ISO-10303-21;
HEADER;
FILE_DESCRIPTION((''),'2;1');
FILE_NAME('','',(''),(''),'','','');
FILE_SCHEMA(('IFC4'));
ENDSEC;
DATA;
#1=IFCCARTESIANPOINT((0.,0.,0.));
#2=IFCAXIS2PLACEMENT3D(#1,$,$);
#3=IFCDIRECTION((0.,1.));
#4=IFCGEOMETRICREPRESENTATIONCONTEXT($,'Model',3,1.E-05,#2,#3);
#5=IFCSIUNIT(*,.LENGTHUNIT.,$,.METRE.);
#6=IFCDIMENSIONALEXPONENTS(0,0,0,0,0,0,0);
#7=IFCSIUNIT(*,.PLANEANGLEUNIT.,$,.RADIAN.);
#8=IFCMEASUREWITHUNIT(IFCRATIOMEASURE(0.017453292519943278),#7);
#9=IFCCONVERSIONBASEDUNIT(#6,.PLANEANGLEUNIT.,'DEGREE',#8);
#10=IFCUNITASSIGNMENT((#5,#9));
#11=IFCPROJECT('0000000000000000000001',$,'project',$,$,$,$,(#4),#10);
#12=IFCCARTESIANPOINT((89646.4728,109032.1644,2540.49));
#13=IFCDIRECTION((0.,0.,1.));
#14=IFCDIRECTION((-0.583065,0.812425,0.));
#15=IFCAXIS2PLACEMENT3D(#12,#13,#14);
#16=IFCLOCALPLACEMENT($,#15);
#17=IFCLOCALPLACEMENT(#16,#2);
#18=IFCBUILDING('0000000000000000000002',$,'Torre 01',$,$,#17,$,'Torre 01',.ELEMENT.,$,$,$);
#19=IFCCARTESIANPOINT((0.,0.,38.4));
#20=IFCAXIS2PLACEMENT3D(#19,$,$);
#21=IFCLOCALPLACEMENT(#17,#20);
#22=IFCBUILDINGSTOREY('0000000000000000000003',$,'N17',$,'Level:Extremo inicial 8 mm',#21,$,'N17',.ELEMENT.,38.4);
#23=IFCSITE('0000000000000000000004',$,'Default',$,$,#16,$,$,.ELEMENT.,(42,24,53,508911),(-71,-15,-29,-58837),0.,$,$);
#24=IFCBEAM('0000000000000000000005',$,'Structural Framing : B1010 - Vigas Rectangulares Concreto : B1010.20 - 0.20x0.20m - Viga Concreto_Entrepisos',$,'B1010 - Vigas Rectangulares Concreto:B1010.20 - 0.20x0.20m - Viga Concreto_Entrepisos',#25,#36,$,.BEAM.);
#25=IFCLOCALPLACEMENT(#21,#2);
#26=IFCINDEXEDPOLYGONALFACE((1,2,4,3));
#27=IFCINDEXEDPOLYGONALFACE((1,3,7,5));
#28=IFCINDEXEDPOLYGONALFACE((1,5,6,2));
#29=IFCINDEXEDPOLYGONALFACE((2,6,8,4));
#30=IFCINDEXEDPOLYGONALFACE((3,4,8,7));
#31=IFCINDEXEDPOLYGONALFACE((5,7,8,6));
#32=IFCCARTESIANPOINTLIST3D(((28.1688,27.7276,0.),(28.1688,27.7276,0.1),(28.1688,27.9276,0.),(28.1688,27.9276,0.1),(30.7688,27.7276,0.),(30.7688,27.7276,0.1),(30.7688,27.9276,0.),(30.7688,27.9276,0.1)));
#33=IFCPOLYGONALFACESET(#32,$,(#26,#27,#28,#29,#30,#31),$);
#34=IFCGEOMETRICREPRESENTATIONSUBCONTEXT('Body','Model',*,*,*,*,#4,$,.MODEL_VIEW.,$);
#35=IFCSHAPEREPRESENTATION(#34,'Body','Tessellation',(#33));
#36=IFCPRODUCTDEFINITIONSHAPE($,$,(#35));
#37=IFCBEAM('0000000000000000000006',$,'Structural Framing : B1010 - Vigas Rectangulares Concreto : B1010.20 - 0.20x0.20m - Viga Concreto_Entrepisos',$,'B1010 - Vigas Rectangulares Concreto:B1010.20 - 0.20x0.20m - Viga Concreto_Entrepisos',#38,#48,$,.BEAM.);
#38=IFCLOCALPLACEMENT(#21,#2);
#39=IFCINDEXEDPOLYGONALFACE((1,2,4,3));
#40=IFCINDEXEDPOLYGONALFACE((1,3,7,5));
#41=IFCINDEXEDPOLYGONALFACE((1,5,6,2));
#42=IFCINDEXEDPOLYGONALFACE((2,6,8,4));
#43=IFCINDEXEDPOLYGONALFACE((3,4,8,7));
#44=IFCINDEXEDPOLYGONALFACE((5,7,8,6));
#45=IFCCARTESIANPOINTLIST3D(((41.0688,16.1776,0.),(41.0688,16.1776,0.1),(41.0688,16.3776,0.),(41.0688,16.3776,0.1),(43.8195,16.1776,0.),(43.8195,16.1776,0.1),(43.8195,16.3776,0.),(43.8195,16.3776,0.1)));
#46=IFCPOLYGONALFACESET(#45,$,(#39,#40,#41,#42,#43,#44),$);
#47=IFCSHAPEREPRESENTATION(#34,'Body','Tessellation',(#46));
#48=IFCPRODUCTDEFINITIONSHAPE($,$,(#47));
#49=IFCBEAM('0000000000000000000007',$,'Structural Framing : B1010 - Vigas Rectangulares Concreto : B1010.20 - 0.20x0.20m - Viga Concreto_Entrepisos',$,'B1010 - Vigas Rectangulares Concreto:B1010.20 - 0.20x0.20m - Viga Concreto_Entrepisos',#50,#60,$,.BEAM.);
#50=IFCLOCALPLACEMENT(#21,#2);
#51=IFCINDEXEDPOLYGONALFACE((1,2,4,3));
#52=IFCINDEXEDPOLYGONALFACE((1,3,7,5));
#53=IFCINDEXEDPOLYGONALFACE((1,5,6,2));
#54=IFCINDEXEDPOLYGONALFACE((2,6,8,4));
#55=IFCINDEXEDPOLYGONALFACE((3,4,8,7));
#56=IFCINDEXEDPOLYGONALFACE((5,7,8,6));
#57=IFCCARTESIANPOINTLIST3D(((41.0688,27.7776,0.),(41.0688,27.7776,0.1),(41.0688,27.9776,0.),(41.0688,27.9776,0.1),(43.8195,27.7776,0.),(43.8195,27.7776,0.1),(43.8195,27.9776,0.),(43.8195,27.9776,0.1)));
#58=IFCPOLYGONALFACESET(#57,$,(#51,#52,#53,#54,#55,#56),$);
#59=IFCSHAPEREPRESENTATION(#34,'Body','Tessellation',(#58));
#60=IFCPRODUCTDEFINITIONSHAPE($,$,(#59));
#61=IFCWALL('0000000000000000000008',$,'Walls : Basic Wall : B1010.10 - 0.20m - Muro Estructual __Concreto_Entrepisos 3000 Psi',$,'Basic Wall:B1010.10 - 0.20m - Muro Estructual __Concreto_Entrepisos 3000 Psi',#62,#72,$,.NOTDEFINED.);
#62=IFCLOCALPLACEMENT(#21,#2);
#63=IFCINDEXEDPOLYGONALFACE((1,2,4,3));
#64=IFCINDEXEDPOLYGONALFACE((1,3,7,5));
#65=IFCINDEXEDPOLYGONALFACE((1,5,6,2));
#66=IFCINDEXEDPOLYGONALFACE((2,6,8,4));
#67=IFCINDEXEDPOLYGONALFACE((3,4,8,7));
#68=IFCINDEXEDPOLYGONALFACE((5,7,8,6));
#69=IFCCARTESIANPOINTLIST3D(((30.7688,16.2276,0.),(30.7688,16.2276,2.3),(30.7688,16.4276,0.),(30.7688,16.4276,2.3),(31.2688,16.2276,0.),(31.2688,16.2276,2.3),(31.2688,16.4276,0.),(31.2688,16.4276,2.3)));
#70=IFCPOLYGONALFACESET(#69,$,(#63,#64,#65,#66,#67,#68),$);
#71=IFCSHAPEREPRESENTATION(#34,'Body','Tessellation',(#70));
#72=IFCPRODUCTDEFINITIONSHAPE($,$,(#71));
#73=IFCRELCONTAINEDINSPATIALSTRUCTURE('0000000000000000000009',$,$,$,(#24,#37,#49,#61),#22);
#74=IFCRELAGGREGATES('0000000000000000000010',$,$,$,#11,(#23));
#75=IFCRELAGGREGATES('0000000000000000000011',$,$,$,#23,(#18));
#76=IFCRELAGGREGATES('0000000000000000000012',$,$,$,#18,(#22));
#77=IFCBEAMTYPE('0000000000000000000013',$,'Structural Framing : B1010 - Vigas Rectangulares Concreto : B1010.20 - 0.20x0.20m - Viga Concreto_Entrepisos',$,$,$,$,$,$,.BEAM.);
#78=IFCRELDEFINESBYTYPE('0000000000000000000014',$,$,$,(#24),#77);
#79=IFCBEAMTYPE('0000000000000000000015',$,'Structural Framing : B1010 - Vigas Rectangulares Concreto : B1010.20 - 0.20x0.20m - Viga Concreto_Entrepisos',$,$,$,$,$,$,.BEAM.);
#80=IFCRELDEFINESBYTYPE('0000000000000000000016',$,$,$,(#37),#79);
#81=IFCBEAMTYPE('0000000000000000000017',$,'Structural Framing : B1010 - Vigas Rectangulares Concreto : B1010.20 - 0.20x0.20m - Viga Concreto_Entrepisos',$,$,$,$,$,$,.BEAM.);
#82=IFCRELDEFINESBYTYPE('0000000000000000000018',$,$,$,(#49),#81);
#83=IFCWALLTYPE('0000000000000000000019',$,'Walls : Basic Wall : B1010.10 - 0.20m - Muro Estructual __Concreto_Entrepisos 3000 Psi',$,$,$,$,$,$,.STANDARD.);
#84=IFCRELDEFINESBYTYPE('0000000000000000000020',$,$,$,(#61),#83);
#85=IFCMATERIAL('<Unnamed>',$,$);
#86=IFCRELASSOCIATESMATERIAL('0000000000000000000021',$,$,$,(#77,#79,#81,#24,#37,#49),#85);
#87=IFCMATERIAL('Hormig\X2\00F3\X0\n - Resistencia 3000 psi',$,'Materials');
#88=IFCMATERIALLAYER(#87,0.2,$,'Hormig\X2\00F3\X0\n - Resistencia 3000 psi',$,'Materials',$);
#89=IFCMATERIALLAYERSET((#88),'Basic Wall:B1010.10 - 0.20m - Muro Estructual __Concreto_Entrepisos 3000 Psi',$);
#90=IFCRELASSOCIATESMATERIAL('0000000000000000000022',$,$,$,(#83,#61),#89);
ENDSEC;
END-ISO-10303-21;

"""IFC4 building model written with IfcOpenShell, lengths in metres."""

from ifc_helpers import new_model, entity, si_unit, converted_unit, direction, frame, frame_2d, origin, place, context, subcontext, project, spatial, polyline, segment, composite_curve, rectangle, outline, extrude, source, transform, mapped, material, layer, layer_set, layer_usage, material_profile, profile_set, profile_usage, type_object, type_shapes, element, save


model = new_model("IFC4")

# Units and contexts
model_context = context("Model", 3, precision=1e-05, world=origin(), true_north=direction((0.0, 1.0)))
body_context = subcontext(model_context, "Body", "Model", "MODEL_VIEW")
ifc_project = project(units=[si_unit("LENGTHUNIT", "METRE"), converted_unit("PLANEANGLEUNIT", "DEGREE", entity("IfcRatioMeasure", 0.017453292519943278), si_unit("PLANEANGLEUNIT", "RADIAN"), dimensions=[0, 0, 0, 0, 0, 0, 0])], contexts=[model_context])

# Site, building, storey
site_placement = place(None, frame((89646.4728, 109032.1644, 2540.49), z_axis=(0.0, 0.0, 1.0), x_axis=(-0.583065, 0.812425, 0.0)))
site = spatial("IfcSite", under=ifc_project, at=site_placement, Name="Default", CompositionType="ELEMENT", RefLatitude=(42, 24, 53, 508911), RefLongitude=(-71, -15, -29, -58837), RefElevation=0.0)
building_placement = place(site_placement, origin())
building = spatial("IfcBuilding", under=site, at=building_placement, Name="Torre 01", LongName="Torre 01", CompositionType="ELEMENT")
storey_placement = place(building_placement, frame((0.0, 0.0, 38.4)))
storey = spatial("IfcBuildingStorey", under=building, at=storey_placement, Name="N17", ObjectType="Level:Extremo inicial 8 mm", LongName="N17", CompositionType="ELEMENT", Elevation=38.4)

# Beams
ifc_material_1 = material(Name="<Unnamed>")
ifc_material_profile_1 = material_profile(ifc_material_1, outline(composite_curve([segment(polyline([(-0.1, 0.0, 0.0), (-0.1, 0.1, 0.0)]), True, "CONTINUOUS"), segment(polyline([(-0.1, 0.1, 0.0), (0.1, 0.1, 0.0)]), True, "CONTINUOUS"), segment(polyline([(0.1, 0.1, 0.0), (0.1, 0.0, 0.0)]), True, "CONTINUOUS"), segment(polyline([(0.1, 0.0, 0.0), (-0.1, 0.0, 0.0)]), True, "CONTINUOUS")], self_intersect=False), kind="CURVE"), Name="B1010.20 - 0.20x0.20m - Viga Concreto_Entrepisos")
ifc_material_profile_2 = material_profile(ifc_material_1, outline(composite_curve([segment(polyline([(-1.3, -0.1, 0.1), (-1.3, 0.1, 0.1)]), True, "CONTINUOUS"), segment(polyline([(-1.3, 0.1, 0.1), (-1.3, 0.1, -0.1)]), True, "CONTINUOUS"), segment(polyline([(-1.3, 0.1, -0.1), (-1.3, -0.1, -0.1)]), True, "CONTINUOUS"), segment(polyline([(-1.3, -0.1, -0.1), (-1.3, -0.1, 0.1)]), True, "CONTINUOUS")], self_intersect=False), kind="CURVE"), Name="B1010.20 - 0.20x0.20m - Viga Concreto_Entrepisos")
ifc_profile_set_1 = profile_set([ifc_material_profile_1, ifc_material_profile_2], Name="B1010.20 - 0.20x0.20m - Viga Concreto_Entrepisos")
ifc_profile_usage_1 = profile_usage(ifc_profile_set_1, cardinal=8)
beam_type_1 = type_object("IfcBeamType", Name="Structural Framing : B1010 - Vigas Rectangulares Concreto : B1010.20 - 0.20x0.20m - Viga Concreto_Entrepisos", PredefinedType="BEAM", material=ifc_profile_set_1)
shared_shape_1 = source(origin(), body_context, "Body", "SweptSolid", [
    extrude(rectangle(XDim=0.1, YDim=0.2, at=frame_2d((0.0, 0.0), x_axis=(1.0, 0.0))), frame((28.1688, 27.8276, 38.45), z_axis=(1.0, 0.0, 0.0), x_axis=(0.0, 0.0, -1.0)), (0.0, 0.0, 1.0), 2.6),
])
type_shapes(beam_type_1, [shared_shape_1])
beam_1_placement = place(storey_placement, frame((0.0, 0.0, -38.4)))
element("IfcBeam", 1, at=beam_1_placement, inside=storey, type_object=beam_type_1, material=ifc_profile_usage_1, Name="Structural Framing : B1010 - Vigas Rectangulares Concreto : B1010.20 - 0.20x0.20m - Viga Concreto_Entrepisos", ObjectType="B1010 - Vigas Rectangulares Concreto:B1010.20 - 0.20x0.20m - Viga Concreto_Entrepisos", PredefinedType="BEAM", context=body_context, shape_type="MappedRepresentation", body=[
    mapped(shared_shape_1, transform((0.0, 0.0, 0.0), scale=1.0)),
])
ifc_profile_usage_2 = profile_usage(ifc_profile_set_1, cardinal=8)
beam_type_2 = type_object("IfcBeamType", Name="Structural Framing : B1010 - Vigas Rectangulares Concreto : B1010.20 - 0.20x0.20m - Viga Concreto_Entrepisos", PredefinedType="BEAM", material=ifc_profile_set_1)
shared_shape_2 = source(origin(), body_context, "Body", "SweptSolid", [
    extrude(rectangle(XDim=0.1, YDim=0.2, at=frame_2d((0.0, 0.0), x_axis=(1.0, 0.0))), frame((43.8195, 16.2776, 38.45), z_axis=(-1.0, 0.0, 0.0), x_axis=(0.0, 0.0, -1.0)), (0.0, 0.0, 1.0), 2.7507),
])
type_shapes(beam_type_2, [shared_shape_2])
beam_2_placement = place(storey_placement, frame((0.0, 0.0, -38.4)))
element("IfcBeam", 2, at=beam_2_placement, inside=storey, type_object=beam_type_2, material=ifc_profile_usage_2, Name="Structural Framing : B1010 - Vigas Rectangulares Concreto : B1010.20 - 0.20x0.20m - Viga Concreto_Entrepisos", ObjectType="B1010 - Vigas Rectangulares Concreto:B1010.20 - 0.20x0.20m - Viga Concreto_Entrepisos", PredefinedType="BEAM", context=body_context, shape_type="MappedRepresentation", body=[
    mapped(shared_shape_2, transform((0.0, 0.0, 0.0), scale=1.0)),
])
ifc_profile_usage_3 = profile_usage(ifc_profile_set_1, cardinal=8)
beam_type_3 = type_object("IfcBeamType", Name="Structural Framing : B1010 - Vigas Rectangulares Concreto : B1010.20 - 0.20x0.20m - Viga Concreto_Entrepisos", PredefinedType="BEAM", material=ifc_profile_set_1)
shared_shape_3 = source(origin(), body_context, "Body", "SweptSolid", [
    extrude(rectangle(XDim=0.1, YDim=0.2, at=frame_2d((0.0, 0.0), x_axis=(1.0, 0.0))), frame((43.8195, 27.8776, 38.45), z_axis=(-1.0, 0.0, 0.0), x_axis=(0.0, 0.0, -1.0)), (0.0, 0.0, 1.0), 2.7507),
])
type_shapes(beam_type_3, [shared_shape_3])
beam_3_placement = place(storey_placement, frame((0.0, 0.0, -38.4)))
element("IfcBeam", 3, at=beam_3_placement, inside=storey, type_object=beam_type_3, material=ifc_profile_usage_3, Name="Structural Framing : B1010 - Vigas Rectangulares Concreto : B1010.20 - 0.20x0.20m - Viga Concreto_Entrepisos", ObjectType="B1010 - Vigas Rectangulares Concreto:B1010.20 - 0.20x0.20m - Viga Concreto_Entrepisos", PredefinedType="BEAM", context=body_context, shape_type="MappedRepresentation", body=[
    mapped(shared_shape_3, transform((0.0, 0.0, 0.0), scale=1.0)),
])

# Wall
ifc_material_2 = material(Name="Hormigón - Resistencia 3000 psi", Category="Materials")
ifc_layer_1 = layer(ifc_material_2, 0.2, Name="Hormigón - Resistencia 3000 psi", Category="Materials")
ifc_layer_set_1 = layer_set([ifc_layer_1], Name="Basic Wall:B1010.10 - 0.20m - Muro Estructual __Concreto_Entrepisos 3000 Psi")
ifc_layer_usage_1 = layer_usage(ifc_layer_set_1, "AXIS2", "NEGATIVE", 0.1)
wall_type = type_object("IfcWallType", Name="Walls : Basic Wall : B1010.10 - 0.20m - Muro Estructual __Concreto_Entrepisos 3000 Psi", PredefinedType="STANDARD", material=ifc_layer_set_1)
wall_placement = place(storey_placement, frame((30.7688, 16.3276, 0.0)))
element("IfcWall", 4, at=wall_placement, inside=storey, type_object=wall_type, material=ifc_layer_usage_1, Name="Walls : Basic Wall : B1010.10 - 0.20m - Muro Estructual __Concreto_Entrepisos 3000 Psi", ObjectType="Basic Wall:B1010.10 - 0.20m - Muro Estructual __Concreto_Entrepisos 3000 Psi", PredefinedType="NOTDEFINED", context=body_context, shape_type="SweptSolid", body=[
    extrude(rectangle(XDim=0.5, YDim=0.2, at=frame_2d((0.25, 0.0), x_axis=(-1.0, 0.0))), origin(), (0.0, 0.0, 1.0), 2.3),
])

save(model, "model.ifc")
